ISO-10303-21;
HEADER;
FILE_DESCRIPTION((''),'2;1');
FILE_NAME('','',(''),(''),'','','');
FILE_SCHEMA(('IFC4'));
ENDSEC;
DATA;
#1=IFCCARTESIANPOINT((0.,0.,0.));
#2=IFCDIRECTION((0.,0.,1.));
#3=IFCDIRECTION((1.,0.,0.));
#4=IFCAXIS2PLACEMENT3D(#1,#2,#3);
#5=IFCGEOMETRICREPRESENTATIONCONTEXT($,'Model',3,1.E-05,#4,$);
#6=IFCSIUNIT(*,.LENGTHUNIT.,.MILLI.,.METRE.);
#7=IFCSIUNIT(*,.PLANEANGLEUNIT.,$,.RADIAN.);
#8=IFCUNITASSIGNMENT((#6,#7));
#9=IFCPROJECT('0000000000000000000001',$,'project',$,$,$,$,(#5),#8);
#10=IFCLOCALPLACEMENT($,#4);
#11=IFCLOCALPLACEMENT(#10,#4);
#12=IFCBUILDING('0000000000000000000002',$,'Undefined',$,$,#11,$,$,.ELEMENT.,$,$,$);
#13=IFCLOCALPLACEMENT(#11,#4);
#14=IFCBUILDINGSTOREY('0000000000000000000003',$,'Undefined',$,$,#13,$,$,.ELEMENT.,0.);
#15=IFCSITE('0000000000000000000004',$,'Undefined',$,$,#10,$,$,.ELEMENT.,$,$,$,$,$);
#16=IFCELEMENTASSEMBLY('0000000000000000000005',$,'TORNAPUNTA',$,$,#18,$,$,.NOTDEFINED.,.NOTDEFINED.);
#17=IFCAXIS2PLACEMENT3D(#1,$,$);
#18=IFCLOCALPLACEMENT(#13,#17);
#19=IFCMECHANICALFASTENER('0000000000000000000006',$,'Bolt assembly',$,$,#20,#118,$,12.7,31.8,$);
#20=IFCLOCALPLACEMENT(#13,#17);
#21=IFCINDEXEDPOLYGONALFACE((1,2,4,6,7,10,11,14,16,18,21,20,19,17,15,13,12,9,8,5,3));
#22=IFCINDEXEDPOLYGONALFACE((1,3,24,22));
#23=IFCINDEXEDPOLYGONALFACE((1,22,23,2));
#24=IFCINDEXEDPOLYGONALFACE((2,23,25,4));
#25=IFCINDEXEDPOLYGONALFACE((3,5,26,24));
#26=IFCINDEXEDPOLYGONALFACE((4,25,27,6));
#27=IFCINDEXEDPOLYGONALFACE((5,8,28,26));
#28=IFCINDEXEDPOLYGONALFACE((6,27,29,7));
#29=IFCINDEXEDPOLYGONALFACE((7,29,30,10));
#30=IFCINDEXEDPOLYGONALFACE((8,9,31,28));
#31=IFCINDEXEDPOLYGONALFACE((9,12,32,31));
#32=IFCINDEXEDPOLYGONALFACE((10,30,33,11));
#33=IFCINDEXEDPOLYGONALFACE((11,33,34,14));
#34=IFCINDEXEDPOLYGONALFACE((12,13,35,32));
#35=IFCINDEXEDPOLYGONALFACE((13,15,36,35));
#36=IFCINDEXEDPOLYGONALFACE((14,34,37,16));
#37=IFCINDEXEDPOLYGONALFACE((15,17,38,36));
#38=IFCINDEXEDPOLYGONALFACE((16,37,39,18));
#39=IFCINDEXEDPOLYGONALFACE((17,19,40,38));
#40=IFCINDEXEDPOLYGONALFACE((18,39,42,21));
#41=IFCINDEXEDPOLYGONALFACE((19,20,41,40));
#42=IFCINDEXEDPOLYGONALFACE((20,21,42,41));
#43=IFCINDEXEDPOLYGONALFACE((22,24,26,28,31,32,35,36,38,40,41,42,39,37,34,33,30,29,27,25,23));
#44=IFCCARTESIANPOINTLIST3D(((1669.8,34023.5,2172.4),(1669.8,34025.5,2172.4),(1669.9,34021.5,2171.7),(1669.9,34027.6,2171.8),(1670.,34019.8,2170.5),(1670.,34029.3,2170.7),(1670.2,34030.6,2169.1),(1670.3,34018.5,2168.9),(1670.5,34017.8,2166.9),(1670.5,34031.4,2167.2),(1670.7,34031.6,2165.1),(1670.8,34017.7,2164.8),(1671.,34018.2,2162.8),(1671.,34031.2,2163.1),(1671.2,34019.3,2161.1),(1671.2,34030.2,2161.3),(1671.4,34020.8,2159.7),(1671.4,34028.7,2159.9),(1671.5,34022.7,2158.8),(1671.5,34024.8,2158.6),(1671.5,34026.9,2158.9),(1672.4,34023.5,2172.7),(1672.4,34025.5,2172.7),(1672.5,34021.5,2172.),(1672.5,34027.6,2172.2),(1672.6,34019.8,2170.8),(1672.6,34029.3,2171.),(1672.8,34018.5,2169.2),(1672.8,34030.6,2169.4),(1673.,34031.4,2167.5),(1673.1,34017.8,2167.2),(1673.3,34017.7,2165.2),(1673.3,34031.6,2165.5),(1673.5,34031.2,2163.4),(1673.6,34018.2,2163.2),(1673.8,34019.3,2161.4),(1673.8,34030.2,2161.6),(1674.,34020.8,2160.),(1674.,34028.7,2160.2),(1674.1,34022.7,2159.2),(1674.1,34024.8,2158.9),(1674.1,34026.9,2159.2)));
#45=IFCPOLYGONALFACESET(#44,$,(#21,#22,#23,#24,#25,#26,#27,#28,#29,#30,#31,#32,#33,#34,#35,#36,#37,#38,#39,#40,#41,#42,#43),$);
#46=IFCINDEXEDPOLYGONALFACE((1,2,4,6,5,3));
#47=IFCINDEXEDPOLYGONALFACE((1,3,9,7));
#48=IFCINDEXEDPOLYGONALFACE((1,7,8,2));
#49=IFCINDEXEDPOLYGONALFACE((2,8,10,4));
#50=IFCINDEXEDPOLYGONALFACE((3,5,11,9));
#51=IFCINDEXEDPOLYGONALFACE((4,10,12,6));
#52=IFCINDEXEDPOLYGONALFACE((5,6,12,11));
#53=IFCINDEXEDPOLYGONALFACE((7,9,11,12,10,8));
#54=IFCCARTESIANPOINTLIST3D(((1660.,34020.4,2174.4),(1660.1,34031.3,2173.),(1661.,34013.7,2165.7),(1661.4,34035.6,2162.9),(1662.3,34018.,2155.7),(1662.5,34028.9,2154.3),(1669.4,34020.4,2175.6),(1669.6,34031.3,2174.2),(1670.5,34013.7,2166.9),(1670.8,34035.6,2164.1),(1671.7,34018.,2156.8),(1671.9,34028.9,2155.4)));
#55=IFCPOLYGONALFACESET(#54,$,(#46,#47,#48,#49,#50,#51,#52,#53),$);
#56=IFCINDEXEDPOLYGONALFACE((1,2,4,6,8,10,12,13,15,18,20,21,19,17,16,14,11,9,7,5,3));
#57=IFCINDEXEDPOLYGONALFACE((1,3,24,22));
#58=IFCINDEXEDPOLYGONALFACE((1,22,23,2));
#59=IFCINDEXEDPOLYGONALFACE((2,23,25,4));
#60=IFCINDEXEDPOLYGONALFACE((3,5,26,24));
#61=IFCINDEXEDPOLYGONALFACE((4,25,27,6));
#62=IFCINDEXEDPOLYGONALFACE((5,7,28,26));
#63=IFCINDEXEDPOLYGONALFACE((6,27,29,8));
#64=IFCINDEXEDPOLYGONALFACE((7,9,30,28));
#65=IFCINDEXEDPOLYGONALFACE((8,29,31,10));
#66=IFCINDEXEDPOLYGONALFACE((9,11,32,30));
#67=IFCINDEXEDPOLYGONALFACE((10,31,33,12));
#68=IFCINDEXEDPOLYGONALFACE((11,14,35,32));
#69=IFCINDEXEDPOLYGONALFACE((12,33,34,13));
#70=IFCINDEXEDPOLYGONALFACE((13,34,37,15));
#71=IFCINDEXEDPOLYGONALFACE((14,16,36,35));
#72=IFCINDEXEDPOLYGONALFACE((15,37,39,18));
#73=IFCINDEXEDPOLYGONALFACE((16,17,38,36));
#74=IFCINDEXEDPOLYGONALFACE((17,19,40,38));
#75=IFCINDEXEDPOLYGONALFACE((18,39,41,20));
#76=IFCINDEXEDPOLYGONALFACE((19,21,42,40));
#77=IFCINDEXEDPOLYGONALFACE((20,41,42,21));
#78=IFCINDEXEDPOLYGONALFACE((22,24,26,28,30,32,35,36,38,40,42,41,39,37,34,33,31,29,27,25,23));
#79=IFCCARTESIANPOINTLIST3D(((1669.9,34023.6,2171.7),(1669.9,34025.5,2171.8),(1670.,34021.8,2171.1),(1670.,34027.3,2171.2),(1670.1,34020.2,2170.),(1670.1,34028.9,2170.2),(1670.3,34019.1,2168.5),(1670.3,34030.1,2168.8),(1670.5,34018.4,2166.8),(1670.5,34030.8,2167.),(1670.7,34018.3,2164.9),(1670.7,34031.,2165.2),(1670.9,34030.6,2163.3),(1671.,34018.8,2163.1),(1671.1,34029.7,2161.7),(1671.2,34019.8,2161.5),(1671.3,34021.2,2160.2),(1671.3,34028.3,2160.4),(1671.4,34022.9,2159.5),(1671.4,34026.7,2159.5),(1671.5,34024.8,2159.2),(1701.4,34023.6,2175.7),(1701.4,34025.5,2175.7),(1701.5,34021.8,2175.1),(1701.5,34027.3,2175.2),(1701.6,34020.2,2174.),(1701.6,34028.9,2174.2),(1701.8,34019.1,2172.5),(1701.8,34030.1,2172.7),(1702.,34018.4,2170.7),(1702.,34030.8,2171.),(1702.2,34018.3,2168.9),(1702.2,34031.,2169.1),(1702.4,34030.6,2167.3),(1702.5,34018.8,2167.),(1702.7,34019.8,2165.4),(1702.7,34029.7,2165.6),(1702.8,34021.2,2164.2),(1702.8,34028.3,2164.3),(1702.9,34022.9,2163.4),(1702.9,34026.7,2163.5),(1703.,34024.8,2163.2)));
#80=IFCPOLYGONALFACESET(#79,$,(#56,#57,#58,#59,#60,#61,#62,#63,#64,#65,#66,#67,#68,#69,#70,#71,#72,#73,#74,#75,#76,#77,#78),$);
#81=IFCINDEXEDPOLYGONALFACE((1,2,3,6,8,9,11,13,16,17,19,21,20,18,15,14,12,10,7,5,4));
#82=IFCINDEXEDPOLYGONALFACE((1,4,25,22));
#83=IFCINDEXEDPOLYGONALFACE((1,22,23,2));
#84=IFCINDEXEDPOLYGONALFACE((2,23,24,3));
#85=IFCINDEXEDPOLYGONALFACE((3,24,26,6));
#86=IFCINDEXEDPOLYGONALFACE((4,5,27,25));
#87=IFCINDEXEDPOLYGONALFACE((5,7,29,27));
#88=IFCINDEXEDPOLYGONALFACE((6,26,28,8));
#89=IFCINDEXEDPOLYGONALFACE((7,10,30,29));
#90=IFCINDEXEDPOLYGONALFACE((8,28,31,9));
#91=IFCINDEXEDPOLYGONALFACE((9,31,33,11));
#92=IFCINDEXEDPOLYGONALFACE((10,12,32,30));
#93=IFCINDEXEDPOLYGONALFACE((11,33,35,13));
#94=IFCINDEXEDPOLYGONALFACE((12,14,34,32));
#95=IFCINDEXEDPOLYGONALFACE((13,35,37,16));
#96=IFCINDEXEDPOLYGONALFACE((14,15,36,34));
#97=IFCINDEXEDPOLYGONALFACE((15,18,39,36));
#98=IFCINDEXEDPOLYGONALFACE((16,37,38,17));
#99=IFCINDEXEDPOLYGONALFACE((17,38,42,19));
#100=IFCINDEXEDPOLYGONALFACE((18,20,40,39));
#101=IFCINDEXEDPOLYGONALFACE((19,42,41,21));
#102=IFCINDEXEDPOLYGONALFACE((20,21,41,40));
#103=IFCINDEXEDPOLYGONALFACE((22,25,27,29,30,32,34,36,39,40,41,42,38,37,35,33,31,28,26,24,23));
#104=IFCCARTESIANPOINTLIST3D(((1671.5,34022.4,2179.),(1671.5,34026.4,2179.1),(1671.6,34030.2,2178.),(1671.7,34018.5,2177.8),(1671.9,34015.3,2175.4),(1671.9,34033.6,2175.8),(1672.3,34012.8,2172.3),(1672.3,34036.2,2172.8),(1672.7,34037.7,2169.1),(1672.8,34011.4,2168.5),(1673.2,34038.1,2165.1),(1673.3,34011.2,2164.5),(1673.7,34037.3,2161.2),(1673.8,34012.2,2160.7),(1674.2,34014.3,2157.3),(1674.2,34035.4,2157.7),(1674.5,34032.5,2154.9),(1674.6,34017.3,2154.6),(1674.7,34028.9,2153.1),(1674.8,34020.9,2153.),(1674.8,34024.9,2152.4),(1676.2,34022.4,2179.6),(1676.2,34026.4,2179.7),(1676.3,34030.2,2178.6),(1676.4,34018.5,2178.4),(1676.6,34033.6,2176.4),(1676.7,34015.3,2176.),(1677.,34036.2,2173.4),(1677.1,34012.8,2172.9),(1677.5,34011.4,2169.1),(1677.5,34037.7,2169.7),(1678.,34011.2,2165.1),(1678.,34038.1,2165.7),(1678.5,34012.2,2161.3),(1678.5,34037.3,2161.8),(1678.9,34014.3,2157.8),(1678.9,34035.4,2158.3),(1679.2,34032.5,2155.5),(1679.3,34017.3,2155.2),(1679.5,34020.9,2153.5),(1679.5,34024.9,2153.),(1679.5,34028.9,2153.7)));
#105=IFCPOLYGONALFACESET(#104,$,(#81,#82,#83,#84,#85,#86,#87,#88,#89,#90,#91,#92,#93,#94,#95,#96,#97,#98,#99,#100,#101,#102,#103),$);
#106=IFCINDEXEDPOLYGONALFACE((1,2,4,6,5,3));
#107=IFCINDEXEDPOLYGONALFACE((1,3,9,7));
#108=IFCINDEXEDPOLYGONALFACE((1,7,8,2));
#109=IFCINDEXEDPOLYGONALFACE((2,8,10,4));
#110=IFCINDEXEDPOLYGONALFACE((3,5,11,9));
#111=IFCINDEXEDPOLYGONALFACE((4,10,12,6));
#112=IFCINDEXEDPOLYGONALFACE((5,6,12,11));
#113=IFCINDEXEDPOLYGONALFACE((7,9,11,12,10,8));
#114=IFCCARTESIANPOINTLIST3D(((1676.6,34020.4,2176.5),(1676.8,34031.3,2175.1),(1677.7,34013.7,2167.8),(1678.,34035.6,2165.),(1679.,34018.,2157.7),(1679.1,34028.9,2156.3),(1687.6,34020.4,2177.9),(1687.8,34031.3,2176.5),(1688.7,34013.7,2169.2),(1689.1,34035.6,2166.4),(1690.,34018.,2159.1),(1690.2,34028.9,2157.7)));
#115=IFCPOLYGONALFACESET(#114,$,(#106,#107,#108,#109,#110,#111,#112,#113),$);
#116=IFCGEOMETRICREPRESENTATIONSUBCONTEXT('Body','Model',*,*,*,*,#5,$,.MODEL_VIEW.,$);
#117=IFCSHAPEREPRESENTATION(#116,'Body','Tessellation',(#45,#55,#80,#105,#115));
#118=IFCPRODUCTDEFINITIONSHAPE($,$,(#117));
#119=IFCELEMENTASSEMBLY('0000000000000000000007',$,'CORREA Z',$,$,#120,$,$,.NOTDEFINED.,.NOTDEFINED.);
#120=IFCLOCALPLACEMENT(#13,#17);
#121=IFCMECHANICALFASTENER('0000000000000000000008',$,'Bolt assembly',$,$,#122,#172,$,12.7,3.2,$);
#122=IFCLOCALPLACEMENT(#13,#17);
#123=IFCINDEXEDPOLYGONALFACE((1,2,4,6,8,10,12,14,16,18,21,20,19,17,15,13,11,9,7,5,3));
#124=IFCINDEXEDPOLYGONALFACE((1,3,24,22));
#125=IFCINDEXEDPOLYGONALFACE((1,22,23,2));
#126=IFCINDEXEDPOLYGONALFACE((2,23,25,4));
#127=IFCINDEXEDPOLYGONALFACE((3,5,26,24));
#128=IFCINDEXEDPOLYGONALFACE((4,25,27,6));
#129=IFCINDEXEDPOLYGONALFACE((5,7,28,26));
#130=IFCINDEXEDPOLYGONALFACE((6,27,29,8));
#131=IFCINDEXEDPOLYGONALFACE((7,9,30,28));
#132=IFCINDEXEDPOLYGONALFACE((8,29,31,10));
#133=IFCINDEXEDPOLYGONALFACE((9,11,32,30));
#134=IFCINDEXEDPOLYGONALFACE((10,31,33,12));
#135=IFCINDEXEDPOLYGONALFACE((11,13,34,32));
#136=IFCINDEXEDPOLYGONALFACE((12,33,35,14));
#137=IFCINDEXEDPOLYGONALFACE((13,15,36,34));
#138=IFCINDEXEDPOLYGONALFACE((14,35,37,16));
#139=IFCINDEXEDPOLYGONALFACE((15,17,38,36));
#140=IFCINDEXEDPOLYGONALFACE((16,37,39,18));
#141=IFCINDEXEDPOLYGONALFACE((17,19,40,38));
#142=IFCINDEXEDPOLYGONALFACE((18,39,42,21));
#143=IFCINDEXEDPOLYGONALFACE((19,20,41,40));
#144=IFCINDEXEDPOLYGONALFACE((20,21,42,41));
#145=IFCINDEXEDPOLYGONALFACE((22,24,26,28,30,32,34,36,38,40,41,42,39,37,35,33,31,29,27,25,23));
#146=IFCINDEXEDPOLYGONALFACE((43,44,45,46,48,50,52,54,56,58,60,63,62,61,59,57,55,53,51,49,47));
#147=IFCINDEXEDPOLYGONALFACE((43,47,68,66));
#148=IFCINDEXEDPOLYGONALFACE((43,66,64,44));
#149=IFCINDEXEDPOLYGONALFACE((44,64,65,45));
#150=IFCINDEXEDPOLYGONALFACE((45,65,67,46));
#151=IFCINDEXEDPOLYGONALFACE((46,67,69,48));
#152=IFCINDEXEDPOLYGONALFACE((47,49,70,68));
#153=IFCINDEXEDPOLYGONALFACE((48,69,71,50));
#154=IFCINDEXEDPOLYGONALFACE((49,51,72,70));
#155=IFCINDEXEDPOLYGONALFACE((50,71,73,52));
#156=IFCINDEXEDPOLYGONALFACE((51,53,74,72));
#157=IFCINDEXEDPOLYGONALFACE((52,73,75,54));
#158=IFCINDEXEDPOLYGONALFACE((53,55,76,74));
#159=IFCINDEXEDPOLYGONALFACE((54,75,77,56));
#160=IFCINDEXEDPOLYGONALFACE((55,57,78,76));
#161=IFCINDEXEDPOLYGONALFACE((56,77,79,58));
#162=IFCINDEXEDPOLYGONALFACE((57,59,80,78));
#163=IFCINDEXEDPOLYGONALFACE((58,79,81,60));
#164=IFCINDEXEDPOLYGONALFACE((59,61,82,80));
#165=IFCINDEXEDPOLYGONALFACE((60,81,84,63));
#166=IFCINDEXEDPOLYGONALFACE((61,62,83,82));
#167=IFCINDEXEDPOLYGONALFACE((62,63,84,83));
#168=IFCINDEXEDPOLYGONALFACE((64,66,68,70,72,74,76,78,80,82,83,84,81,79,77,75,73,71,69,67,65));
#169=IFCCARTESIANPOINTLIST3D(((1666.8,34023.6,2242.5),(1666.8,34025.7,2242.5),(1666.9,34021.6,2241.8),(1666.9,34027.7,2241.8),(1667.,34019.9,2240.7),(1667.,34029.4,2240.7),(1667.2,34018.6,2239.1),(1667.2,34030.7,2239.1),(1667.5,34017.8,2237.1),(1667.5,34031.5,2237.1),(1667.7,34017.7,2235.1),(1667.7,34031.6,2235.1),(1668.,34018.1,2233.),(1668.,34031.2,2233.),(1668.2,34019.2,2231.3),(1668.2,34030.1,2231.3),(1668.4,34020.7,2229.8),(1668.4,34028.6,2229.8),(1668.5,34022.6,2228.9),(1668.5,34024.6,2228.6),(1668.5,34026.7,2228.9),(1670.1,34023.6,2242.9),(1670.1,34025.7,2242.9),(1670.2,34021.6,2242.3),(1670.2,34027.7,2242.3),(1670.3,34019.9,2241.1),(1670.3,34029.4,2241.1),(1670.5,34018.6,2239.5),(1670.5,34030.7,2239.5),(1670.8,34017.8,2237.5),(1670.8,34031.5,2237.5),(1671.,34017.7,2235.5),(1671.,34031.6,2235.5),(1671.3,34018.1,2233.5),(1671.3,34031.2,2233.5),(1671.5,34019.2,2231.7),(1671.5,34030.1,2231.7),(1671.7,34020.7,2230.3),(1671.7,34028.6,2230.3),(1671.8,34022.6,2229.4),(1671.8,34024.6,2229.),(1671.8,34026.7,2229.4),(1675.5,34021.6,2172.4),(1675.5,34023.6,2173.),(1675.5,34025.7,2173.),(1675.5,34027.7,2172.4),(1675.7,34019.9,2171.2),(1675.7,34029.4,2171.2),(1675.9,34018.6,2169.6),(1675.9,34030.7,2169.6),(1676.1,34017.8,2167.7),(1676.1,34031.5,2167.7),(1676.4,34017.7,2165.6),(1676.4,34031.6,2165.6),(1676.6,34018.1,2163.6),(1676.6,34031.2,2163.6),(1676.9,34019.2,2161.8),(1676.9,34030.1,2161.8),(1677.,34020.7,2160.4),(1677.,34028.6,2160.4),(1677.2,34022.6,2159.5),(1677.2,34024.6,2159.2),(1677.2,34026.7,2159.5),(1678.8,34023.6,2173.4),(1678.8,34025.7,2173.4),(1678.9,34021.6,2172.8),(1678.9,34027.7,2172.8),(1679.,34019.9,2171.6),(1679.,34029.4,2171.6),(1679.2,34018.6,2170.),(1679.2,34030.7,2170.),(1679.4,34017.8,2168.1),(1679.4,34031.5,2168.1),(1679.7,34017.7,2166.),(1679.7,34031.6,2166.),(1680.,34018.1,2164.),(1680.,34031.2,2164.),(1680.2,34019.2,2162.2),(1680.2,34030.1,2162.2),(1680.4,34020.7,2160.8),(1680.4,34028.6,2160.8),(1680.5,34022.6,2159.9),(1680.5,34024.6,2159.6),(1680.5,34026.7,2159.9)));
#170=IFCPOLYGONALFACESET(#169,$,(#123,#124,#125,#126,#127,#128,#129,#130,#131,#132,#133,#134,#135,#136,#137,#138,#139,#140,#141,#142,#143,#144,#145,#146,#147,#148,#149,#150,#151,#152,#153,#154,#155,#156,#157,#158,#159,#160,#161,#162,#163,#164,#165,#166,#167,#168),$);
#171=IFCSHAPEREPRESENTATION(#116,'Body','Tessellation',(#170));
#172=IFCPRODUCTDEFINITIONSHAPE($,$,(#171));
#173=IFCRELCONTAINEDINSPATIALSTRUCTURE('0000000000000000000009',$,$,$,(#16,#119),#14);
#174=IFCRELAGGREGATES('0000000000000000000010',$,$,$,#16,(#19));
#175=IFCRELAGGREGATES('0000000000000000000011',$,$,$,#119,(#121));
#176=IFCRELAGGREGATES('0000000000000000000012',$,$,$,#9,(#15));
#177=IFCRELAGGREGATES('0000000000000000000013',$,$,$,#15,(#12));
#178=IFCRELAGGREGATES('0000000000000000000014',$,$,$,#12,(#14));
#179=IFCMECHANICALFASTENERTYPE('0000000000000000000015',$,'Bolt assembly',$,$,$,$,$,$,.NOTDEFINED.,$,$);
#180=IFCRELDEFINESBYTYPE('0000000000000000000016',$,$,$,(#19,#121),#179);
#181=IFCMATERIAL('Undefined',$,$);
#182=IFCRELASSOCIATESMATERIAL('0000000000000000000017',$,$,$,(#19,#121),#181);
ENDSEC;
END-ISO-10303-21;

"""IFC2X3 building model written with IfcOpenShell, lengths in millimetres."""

from ifc_helpers import new_model, si_unit, frame, origin_with_axes, origin_2d_with_axis, place, context, subcontext, project, spatial, polyline, circle, outline, extrude, source, transform, mapped, material, type_object, element, aggregate, save


model = new_model("IFC2X3")

# Units and contexts
model_context = context("Model", 3, precision=1e-05, world=origin_with_axes())
body_context = subcontext(model_context, "Body", "Model", "MODEL_VIEW")
ifc_project = project(units=[si_unit("LENGTHUNIT", "METRE", prefix="MILLI"), si_unit("PLANEANGLEUNIT", "RADIAN")], contexts=[model_context])

# Site, building, storey
site_placement = place(None, origin_with_axes())
site = spatial("IfcSite", under=ifc_project, at=site_placement, Name="Undefined", CompositionType="ELEMENT")
building_placement = place(site_placement, origin_with_axes())
building = spatial("IfcBuilding", under=site, at=building_placement, Name="Undefined", CompositionType="ELEMENT")
storey_placement = place(building_placement, origin_with_axes())
storey = spatial("IfcBuildingStorey", under=building, at=storey_placement, Name="Undefined", CompositionType="ELEMENT", Elevation=0.0)

# Shared definitions
ifc_material_1 = material(Name="Undefined")
mechanical_fastener_type = type_object("IfcMechanicalFastenerType", Name="Bolt assembly")

# Element assemblies, mechanical fasteners
assembly_1_placement = place(storey_placement, origin_with_axes())
assembly_1 = element("IfcElementAssembly", 1, at=assembly_1_placement, inside=storey, Name="TORNAPUNTA", AssemblyPlace="NOTDEFINED", PredefinedType="NOTDEFINED")
shared_shape_1 = source(origin_with_axes(), body_context, "Body", "SweptSolid", [
    extrude(circle(Radius=7.0, at=origin_2d_with_axis()), frame((0.0, -2.5, 0.0), z_axis=(0.0, 1.0, 0.0), x_axis=(1.0, 0.0, 0.0)), (0.0, 0.0, 1.0), 2.6),
    extrude(outline(polyline([(9.5, -5.5), (9.5, 5.5), (0.0, 11.0), (-9.5, 5.5), (-9.5, -5.5), (0.0, -11.0), (9.5, -5.5)])), frame((0.0, -12.0, 0.0), z_axis=(0.0, 1.0, 0.0), x_axis=(1.0, 0.0, 0.0)), (0.0, 0.0, 1.0), 9.5),
    extrude(circle(Radius=6.3, at=origin_2d_with_axis()), frame((0.0, -2.5, 0.0), z_axis=(0.0, 1.0, 0.0), x_axis=(1.0, 0.0, 0.0)), (0.0, 0.0, 1.0), 31.8),
    extrude(circle(Radius=13.5, at=origin_2d_with_axis()), frame((0.0, 0.0, 0.0), z_axis=(0.0, 1.0, 0.0), x_axis=(1.0, 0.0, 0.0)), (0.0, 0.0, 1.0), 4.8),
    extrude(outline(polyline([(9.5, -5.5), (9.5, 5.5), (0.0, 11.0), (-9.5, 5.5), (-9.5, -5.5), (0.0, -11.0), (9.5, -5.5)])), frame((0.0, 4.8, 0.0), z_axis=(0.0, 1.0, 0.0), x_axis=(1.0, 0.0, 0.0)), (0.0, 0.0, 1.0), 11.1),
])
mechanical_fastener_1_placement = place(assembly_1_placement, frame((1673.1, 34024.7, 2165.8), z_axis=(0.098611, -0.606774, -0.788734), x_axis=(0.075276, 0.794875, -0.602086)))
mechanical_fastener_1 = element("IfcMechanicalFastener", 2, at=mechanical_fastener_1_placement, type_object=mechanical_fastener_type, material=ifc_material_1, Name="Bolt assembly", NominalDiameter=12.7, NominalLength=31.8, context=body_context, shape_type="MappedRepresentation", body=[
    mapped(shared_shape_1, transform((0.0, 0.0, 0.0))),
])
aggregate(assembly_1, [mechanical_fastener_1])
assembly_2_placement = place(storey_placement, origin_with_axes())
assembly_2 = element("IfcElementAssembly", 3, at=assembly_2_placement, inside=storey, Name="CORREA Z", AssemblyPlace="NOTDEFINED", PredefinedType="NOTDEFINED")
shared_shape_2 = source(origin_with_axes(), body_context, "Body", "SweptSolid", [
    extrude(circle(Radius=7.0, at=origin_2d_with_axis()), frame((0.0, 3.2, 0.0), z_axis=(0.0, 1.0, 0.0), x_axis=(1.0, 0.0, 0.0)), (0.0, 0.0, 1.0), 3.3),
])
mechanical_fastener_2_placement = place(assembly_2_placement, frame((1664.5, 34024.6, 2235.2), z_axis=(0.0, -1.0, 0.0), x_axis=(0.124059, 0.0, -0.992275)))
mechanical_fastener_2 = element("IfcMechanicalFastener", 4, at=mechanical_fastener_2_placement, type_object=mechanical_fastener_type, material=ifc_material_1, Name="Bolt assembly", NominalDiameter=12.7, NominalLength=3.2, context=body_context, shape_type="MappedRepresentation", body=[
    mapped(shared_shape_2, transform((0.0, 0.0, 0.0))),
    mapped(shared_shape_2, transform((70.0, 0.0, 0.0))),
])
aggregate(assembly_2, [mechanical_fastener_2])

save(model, "model.ifc")
